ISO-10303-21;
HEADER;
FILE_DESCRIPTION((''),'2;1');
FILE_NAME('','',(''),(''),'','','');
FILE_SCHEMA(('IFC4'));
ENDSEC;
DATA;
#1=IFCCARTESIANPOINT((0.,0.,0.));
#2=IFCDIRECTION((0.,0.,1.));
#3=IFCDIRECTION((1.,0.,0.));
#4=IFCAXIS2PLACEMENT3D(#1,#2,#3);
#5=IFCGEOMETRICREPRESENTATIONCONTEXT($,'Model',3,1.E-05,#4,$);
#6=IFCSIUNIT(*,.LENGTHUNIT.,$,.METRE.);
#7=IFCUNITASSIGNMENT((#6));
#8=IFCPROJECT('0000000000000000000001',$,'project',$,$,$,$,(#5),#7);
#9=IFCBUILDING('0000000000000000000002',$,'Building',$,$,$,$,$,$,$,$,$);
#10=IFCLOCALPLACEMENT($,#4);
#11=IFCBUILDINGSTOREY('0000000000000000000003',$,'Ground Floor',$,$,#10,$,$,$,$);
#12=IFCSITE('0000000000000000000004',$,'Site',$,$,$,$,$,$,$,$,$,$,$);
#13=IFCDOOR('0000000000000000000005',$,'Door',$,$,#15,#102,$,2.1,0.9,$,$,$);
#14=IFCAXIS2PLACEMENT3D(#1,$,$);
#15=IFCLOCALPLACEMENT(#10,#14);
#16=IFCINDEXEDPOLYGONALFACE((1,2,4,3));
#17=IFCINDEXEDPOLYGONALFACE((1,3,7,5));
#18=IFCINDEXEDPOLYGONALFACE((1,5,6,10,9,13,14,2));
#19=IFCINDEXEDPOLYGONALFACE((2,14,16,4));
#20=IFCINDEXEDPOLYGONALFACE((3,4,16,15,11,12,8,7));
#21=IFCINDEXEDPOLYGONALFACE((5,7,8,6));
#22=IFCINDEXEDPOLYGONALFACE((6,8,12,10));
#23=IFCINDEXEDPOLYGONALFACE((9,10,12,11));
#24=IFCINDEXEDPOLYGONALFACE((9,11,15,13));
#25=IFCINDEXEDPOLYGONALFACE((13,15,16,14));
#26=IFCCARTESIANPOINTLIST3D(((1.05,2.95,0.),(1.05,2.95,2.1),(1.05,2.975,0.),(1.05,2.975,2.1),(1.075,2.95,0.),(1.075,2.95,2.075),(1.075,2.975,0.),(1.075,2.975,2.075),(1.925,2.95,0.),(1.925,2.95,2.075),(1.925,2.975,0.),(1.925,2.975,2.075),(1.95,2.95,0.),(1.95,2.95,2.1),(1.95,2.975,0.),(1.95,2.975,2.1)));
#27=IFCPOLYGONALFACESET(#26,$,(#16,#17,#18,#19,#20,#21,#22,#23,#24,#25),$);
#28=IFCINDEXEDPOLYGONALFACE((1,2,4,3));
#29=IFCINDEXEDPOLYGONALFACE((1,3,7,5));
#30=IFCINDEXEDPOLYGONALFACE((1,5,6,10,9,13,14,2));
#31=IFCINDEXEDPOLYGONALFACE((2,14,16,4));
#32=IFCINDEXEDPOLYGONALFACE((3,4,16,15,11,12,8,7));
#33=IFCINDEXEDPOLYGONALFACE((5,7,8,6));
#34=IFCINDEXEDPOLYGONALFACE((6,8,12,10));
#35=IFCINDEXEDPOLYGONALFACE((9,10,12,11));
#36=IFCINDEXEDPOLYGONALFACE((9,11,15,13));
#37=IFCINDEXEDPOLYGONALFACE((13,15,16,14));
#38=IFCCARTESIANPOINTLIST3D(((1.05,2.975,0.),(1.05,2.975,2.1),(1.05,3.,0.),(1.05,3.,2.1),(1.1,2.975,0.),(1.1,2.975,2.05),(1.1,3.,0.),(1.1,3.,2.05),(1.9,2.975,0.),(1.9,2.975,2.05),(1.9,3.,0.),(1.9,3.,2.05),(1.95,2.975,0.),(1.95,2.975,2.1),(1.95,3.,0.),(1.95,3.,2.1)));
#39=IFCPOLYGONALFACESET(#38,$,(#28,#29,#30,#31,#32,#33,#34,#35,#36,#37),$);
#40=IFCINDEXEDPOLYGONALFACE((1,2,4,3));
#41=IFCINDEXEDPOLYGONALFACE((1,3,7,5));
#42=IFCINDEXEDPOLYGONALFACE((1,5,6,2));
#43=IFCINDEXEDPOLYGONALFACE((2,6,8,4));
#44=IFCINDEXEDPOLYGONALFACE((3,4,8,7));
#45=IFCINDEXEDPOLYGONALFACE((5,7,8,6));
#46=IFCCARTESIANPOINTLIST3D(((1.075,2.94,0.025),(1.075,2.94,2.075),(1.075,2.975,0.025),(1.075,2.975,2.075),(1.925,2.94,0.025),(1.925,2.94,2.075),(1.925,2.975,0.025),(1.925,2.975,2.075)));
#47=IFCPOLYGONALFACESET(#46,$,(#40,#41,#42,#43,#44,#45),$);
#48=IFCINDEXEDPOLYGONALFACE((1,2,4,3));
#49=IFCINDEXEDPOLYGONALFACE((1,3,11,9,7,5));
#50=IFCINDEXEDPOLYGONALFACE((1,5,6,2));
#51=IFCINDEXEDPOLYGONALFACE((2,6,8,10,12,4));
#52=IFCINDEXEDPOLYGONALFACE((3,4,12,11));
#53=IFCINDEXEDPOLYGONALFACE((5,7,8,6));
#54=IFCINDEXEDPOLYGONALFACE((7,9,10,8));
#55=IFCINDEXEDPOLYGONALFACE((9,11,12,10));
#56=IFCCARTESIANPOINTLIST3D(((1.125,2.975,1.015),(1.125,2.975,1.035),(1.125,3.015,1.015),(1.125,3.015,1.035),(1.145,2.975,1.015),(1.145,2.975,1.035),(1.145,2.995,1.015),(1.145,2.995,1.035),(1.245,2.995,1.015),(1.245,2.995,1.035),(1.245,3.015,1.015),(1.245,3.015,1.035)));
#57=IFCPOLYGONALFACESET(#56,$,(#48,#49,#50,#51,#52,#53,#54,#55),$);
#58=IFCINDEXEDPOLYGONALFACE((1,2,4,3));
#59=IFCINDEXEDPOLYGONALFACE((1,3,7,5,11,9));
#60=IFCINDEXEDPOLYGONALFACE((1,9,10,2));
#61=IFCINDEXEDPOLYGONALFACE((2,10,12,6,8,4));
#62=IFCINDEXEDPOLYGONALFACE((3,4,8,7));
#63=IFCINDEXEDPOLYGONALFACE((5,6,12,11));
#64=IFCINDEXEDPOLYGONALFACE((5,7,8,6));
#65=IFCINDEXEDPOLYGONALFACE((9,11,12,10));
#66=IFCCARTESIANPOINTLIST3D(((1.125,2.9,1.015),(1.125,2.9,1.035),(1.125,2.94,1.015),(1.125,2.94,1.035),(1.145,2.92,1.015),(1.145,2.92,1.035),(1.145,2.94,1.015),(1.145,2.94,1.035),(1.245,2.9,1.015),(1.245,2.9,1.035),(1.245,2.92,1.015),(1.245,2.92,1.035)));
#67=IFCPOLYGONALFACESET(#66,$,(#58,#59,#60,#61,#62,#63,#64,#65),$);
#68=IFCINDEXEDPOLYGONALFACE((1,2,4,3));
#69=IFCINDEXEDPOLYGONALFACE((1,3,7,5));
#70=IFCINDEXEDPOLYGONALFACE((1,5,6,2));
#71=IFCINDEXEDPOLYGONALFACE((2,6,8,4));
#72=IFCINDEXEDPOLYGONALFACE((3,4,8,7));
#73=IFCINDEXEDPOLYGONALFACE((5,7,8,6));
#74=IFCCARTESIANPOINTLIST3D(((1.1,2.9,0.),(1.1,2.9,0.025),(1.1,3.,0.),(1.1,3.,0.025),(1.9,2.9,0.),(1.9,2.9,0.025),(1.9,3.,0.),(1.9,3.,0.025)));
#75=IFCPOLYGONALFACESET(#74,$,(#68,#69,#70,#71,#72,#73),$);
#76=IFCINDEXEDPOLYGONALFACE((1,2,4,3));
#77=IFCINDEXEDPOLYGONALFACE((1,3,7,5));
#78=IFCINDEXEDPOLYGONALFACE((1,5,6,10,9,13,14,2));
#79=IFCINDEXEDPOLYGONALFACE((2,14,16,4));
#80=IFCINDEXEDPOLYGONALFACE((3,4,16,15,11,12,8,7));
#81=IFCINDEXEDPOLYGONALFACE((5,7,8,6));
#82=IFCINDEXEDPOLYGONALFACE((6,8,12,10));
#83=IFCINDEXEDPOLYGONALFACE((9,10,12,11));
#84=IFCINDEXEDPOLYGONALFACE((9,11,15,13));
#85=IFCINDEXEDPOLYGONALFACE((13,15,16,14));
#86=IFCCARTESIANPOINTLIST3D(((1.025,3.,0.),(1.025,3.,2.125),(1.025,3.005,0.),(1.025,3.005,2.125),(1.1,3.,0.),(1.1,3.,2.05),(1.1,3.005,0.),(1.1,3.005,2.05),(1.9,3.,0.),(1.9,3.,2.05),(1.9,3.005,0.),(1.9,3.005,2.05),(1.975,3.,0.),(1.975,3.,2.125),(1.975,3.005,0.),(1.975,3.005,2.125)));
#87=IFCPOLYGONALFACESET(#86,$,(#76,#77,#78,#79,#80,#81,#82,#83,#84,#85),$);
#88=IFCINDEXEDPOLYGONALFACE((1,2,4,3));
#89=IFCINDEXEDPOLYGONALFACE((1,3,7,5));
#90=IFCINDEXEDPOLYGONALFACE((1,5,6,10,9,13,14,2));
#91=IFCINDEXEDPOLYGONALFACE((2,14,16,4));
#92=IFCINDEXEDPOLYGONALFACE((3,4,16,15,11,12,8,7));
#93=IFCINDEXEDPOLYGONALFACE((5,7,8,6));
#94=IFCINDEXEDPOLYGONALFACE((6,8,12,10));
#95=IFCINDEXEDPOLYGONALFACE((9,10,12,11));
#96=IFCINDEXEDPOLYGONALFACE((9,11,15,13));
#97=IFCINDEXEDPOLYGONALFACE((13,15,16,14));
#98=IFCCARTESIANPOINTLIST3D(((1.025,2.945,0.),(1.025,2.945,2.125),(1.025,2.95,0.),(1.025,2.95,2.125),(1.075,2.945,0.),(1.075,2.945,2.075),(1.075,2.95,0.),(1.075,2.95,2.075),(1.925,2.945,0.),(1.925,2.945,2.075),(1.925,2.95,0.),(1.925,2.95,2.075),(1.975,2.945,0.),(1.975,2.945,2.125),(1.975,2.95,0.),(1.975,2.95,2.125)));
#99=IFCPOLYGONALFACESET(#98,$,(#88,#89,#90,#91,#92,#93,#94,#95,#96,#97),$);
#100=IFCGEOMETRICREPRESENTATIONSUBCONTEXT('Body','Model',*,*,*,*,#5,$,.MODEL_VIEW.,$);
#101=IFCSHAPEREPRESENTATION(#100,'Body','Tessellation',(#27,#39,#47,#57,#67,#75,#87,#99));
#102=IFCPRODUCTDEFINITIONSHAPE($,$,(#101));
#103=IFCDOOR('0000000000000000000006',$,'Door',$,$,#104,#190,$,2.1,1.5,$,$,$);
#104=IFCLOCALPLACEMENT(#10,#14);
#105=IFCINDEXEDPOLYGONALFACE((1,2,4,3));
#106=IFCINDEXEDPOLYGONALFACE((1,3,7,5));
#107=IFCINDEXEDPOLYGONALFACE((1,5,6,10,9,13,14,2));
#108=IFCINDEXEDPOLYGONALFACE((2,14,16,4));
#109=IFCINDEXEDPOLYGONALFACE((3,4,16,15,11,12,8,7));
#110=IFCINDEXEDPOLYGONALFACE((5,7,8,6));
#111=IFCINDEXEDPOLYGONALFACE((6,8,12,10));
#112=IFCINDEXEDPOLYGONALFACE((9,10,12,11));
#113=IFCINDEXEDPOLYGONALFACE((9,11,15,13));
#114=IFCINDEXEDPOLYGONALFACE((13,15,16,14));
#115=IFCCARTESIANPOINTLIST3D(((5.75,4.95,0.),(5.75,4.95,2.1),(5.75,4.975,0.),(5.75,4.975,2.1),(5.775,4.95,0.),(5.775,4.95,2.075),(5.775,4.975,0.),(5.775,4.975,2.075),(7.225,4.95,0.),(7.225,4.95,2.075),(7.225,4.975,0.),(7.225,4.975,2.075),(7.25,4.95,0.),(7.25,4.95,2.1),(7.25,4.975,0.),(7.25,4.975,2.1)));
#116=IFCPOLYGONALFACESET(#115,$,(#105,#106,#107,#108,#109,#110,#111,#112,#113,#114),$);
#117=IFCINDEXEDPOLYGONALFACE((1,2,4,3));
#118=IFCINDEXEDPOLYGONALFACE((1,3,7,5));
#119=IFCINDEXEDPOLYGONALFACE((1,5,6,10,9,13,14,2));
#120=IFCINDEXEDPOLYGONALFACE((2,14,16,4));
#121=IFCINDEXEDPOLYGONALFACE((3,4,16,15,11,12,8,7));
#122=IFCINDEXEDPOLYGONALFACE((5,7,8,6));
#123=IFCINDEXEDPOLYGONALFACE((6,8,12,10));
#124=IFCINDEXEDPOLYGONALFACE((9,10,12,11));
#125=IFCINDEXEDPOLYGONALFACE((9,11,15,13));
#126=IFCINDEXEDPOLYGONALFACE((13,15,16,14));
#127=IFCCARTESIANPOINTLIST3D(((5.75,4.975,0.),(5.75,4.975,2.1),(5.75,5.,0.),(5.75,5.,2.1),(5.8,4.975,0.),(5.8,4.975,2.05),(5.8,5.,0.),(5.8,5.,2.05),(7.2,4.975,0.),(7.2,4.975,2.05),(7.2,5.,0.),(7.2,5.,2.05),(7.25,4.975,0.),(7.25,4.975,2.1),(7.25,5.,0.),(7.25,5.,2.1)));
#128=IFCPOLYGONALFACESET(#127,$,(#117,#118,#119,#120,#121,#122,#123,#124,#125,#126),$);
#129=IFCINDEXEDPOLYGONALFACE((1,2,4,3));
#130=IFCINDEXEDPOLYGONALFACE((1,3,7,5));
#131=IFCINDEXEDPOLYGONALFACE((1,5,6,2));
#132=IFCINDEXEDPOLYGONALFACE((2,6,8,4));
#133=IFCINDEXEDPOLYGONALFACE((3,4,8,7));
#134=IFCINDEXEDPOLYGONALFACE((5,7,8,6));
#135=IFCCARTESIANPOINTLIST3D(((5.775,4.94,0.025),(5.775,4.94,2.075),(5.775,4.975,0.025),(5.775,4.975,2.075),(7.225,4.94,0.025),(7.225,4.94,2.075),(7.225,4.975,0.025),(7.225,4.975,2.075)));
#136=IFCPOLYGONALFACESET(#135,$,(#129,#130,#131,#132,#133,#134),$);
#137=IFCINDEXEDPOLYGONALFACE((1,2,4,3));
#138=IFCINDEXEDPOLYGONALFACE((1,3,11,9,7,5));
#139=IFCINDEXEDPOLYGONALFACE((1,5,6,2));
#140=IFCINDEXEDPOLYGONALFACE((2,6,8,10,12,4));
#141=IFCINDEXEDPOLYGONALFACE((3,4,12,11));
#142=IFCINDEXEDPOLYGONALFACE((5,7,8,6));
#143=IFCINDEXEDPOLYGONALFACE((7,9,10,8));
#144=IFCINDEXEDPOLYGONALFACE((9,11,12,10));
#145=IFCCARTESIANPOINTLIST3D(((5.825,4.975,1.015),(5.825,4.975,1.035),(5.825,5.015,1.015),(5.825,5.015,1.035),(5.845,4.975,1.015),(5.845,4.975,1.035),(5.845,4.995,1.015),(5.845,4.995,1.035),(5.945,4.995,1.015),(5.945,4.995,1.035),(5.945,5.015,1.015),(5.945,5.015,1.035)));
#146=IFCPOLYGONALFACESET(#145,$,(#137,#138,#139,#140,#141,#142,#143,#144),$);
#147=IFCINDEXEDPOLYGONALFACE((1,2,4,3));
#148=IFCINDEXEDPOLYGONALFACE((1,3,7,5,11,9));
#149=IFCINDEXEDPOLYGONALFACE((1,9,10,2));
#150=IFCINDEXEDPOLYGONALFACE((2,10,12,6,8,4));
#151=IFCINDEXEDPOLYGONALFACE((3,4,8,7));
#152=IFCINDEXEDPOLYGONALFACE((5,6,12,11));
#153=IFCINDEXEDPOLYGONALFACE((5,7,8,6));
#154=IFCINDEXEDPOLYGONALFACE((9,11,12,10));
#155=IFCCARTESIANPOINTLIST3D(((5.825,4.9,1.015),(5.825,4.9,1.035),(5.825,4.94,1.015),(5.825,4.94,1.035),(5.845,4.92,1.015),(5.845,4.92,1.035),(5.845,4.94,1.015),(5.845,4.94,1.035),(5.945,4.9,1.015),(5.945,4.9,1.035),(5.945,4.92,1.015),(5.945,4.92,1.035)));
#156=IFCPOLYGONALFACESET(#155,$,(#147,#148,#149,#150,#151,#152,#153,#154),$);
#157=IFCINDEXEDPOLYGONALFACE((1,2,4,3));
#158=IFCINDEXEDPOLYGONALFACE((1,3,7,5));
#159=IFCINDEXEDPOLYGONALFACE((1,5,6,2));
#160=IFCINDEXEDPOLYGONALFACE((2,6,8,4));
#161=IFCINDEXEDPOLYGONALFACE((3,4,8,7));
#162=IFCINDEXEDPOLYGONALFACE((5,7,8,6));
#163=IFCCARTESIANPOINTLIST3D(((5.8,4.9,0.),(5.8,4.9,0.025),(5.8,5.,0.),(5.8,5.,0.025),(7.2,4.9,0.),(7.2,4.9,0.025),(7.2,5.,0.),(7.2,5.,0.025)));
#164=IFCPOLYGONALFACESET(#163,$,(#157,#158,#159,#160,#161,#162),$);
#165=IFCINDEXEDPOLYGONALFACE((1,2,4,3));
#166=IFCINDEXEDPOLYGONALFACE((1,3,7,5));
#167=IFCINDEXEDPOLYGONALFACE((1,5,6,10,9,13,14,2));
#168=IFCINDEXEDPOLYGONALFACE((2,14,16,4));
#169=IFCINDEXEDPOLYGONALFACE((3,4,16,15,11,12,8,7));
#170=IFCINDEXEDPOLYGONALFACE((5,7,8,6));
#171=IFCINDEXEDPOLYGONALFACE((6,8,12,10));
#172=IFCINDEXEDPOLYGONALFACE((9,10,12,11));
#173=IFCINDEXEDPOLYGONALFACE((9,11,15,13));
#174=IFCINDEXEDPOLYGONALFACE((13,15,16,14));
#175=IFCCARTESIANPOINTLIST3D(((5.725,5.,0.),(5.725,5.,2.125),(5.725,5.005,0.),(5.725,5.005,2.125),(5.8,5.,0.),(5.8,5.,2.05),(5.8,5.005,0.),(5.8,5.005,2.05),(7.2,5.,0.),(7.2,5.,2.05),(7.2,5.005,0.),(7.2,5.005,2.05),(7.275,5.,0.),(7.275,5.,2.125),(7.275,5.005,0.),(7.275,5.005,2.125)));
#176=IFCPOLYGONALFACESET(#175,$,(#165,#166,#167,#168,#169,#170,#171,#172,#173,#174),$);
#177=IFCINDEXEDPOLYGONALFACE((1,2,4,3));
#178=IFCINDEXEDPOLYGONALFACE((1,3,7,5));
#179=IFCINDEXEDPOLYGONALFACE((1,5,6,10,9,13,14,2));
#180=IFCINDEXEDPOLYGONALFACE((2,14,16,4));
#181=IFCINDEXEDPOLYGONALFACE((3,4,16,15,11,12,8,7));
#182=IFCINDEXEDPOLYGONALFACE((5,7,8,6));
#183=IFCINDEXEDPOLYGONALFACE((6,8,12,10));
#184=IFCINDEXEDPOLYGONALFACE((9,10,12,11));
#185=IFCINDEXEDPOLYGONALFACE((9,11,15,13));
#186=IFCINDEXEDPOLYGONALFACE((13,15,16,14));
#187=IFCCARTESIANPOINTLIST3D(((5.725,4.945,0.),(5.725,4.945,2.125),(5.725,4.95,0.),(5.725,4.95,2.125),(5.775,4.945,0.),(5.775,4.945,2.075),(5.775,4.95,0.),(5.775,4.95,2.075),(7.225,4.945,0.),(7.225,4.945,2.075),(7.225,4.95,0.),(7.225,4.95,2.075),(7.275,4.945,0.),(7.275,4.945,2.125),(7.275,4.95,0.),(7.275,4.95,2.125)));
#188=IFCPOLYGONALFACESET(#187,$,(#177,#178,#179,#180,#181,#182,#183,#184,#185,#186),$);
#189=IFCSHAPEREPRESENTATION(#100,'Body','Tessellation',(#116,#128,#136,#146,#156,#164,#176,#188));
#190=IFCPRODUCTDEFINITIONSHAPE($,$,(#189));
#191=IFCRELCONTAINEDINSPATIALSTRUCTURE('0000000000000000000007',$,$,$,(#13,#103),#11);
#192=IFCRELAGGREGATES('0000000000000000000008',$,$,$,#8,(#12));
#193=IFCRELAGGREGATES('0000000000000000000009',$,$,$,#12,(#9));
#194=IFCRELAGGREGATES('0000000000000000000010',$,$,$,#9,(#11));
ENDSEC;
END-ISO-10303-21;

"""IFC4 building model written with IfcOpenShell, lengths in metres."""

from ifc_helpers import new_model, si_unit, frame, origin_with_axes, place, context, subcontext, project, spatial, line, indexed_curve, outline, extrude, element, save


model = new_model("IFC4")

# Units and contexts
model_context = context("Model", 3, precision=1e-05, world=origin_with_axes())
body_context = subcontext(model_context, "Body", "Model", "MODEL_VIEW")
ifc_project = project(units=[si_unit("LENGTHUNIT", "METRE")], contexts=[model_context])

# Site, building, storey
site = spatial("IfcSite", under=ifc_project, Name="Site")
building = spatial("IfcBuilding", under=site, Name="Building")
storey_placement = place(None, origin_with_axes())
storey = spatial("IfcBuildingStorey", under=building, at=storey_placement, Name="Ground Floor")

# Doors
door_1_placement = place(storey_placement, frame((1.95, 3.0, 0.0), z_axis=(0.0, 0.0, 1.0), x_axis=(-1.0, 0.0, 0.0)))
element("IfcDoor", 1, at=door_1_placement, inside=storey, Name="Door", OverallHeight=2.1, OverallWidth=0.9, context=body_context, shape_type="SweptSolid", body=[
    extrude(outline(indexed_curve([(0.0, 0.0), (0.0, 2.1), (0.9, 2.1), (0.9, 0.0), (0.875, 0.0), (0.875, 2.075), (0.025, 2.075), (0.025, 0.0)], segments=[line(1, 2, 3, 4, 5, 6, 7, 8, 1)])), frame((0.0, 0.025, 0.0), z_axis=(0.0, -1.0, 0.0), x_axis=(1.0, 0.0, 0.0)), (0.0, 0.0, -1.0), 0.025),
    extrude(outline(indexed_curve([(0.0, 0.0), (0.0, 2.1), (0.9, 2.1), (0.9, 0.0), (0.85, 0.0), (0.85, 2.05), (0.05, 2.05), (0.05, 0.0)], segments=[line(1, 2, 3, 4, 5, 6, 7, 8, 1)])), frame((0.0, 0.0, 0.0), z_axis=(0.0, -1.0, 0.0), x_axis=(1.0, 0.0, 0.0)), (0.0, 0.0, -1.0), 0.025),
    extrude(outline(indexed_curve([(0.0, 0.0), (0.85, 0.0), (0.85, 0.035), (0.0, 0.035)], segments=[line(1, 2, 3, 4, 1)])), frame((0.025, 0.025, 0.025), z_axis=(0.0, 0.0, 1.0), x_axis=(1.0, 0.0, 0.0)), (0.0, 0.0, 1.0), 2.05),
    extrude(outline(indexed_curve([(0.0, 0.0), (0.0, -0.04), (-0.12, -0.04), (-0.12, -0.02), (-0.02, -0.02), (-0.02, 0.0)], segments=[line(1, 2, 3, 4, 5, 6, 1)])), frame((0.825, 0.025, 1.015), z_axis=(0.0, 0.0, 1.0), x_axis=(1.0, 0.0, 0.0)), (0.0, 0.0, 1.0), 0.02),
    extrude(outline(indexed_curve([(0.0, 0.0), (0.0, 0.04), (-0.12, 0.04), (-0.12, 0.02), (-0.02, 0.02), (-0.02, 0.0)], segments=[line(1, 2, 3, 4, 5, 6, 1)])), frame((0.825, 0.06, 1.015), z_axis=(0.0, 0.0, 1.0), x_axis=(1.0, 0.0, 0.0)), (0.0, 0.0, 1.0), 0.02),
    extrude(outline(indexed_curve([(0.0, 0.0), (0.8, 0.0), (0.8, 0.1), (0.0, 0.1)], segments=[line(1, 2, 3, 4, 1)])), frame((0.05, 0.0, 0.0), z_axis=(0.0, 0.0, 1.0), x_axis=(1.0, 0.0, 0.0)), (0.0, 0.0, 1.0), 0.025),
    extrude(outline(indexed_curve([(0.0, 0.0), (0.0, 2.125), (0.95, 2.125), (0.95, 0.0), (0.875, 0.0), (0.875, 2.05), (0.075, 2.05), (0.075, 0.0)], segments=[line(1, 2, 3, 4, 5, 6, 7, 8, 1)])), frame((-0.025, -0.005, 0.0), z_axis=(0.0, -1.0, 0.0), x_axis=(1.0, 0.0, 0.0)), (0.0, 0.0, -1.0), 0.005),
    extrude(outline(indexed_curve([(0.0, 0.0), (0.0, 2.125), (0.95, 2.125), (0.95, 0.0), (0.9, 0.0), (0.9, 2.075), (0.05, 2.075), (0.05, 0.0)], segments=[line(1, 2, 3, 4, 5, 6, 7, 8, 1)])), frame((-0.025, 0.05, 0.0), z_axis=(0.0, -1.0, 0.0), x_axis=(1.0, 0.0, 0.0)), (0.0, 0.0, -1.0), 0.005),
])
door_2_placement = place(storey_placement, frame((7.25, 5.0, 0.0), z_axis=(0.0, 0.0, 1.0), x_axis=(-1.0, 0.0, 0.0)))
element("IfcDoor", 2, at=door_2_placement, inside=storey, Name="Door", OverallHeight=2.1, OverallWidth=1.5, context=body_context, shape_type="SweptSolid", body=[
    extrude(outline(indexed_curve([(0.0, 0.0), (0.0, 2.1), (1.5, 2.1), (1.5, 0.0), (1.475, 0.0), (1.475, 2.075), (0.025, 2.075), (0.025, 0.0)], segments=[line(1, 2, 3, 4, 5, 6, 7, 8, 1)])), frame((0.0, 0.025, 0.0), z_axis=(0.0, -1.0, 0.0), x_axis=(1.0, 0.0, 0.0)), (0.0, 0.0, -1.0), 0.025),
    extrude(outline(indexed_curve([(0.0, 0.0), (0.0, 2.1), (1.5, 2.1), (1.5, 0.0), (1.45, 0.0), (1.45, 2.05), (0.05, 2.05), (0.05, 0.0)], segments=[line(1, 2, 3, 4, 5, 6, 7, 8, 1)])), frame((0.0, 0.0, 0.0), z_axis=(0.0, -1.0, 0.0), x_axis=(1.0, 0.0, 0.0)), (0.0, 0.0, -1.0), 0.025),
    extrude(outline(indexed_curve([(0.0, 0.0), (1.45, 0.0), (1.45, 0.035), (0.0, 0.035)], segments=[line(1, 2, 3, 4, 1)])), frame((0.025, 0.025, 0.025), z_axis=(0.0, 0.0, 1.0), x_axis=(1.0, 0.0, 0.0)), (0.0, 0.0, 1.0), 2.05),
    extrude(outline(indexed_curve([(0.0, 0.0), (0.0, -0.04), (-0.12, -0.04), (-0.12, -0.02), (-0.02, -0.02), (-0.02, 0.0)], segments=[line(1, 2, 3, 4, 5, 6, 1)])), frame((1.425, 0.025, 1.015), z_axis=(0.0, 0.0, 1.0), x_axis=(1.0, 0.0, 0.0)), (0.0, 0.0, 1.0), 0.02),
    extrude(outline(indexed_curve([(0.0, 0.0), (0.0, 0.04), (-0.12, 0.04), (-0.12, 0.02), (-0.02, 0.02), (-0.02, 0.0)], segments=[line(1, 2, 3, 4, 5, 6, 1)])), frame((1.425, 0.06, 1.015), z_axis=(0.0, 0.0, 1.0), x_axis=(1.0, 0.0, 0.0)), (0.0, 0.0, 1.0), 0.02),
    extrude(outline(indexed_curve([(0.0, 0.0), (1.4, 0.0), (1.4, 0.1), (0.0, 0.1)], segments=[line(1, 2, 3, 4, 1)])), frame((0.05, 0.0, 0.0), z_axis=(0.0, 0.0, 1.0), x_axis=(1.0, 0.0, 0.0)), (0.0, 0.0, 1.0), 0.025),
    extrude(outline(indexed_curve([(0.0, 0.0), (0.0, 2.125), (1.55, 2.125), (1.55, 0.0), (1.475, 0.0), (1.475, 2.05), (0.075, 2.05), (0.075, 0.0)], segments=[line(1, 2, 3, 4, 5, 6, 7, 8, 1)])), frame((-0.025, -0.005, 0.0), z_axis=(0.0, -1.0, 0.0), x_axis=(1.0, 0.0, 0.0)), (0.0, 0.0, -1.0), 0.005),
    extrude(outline(indexed_curve([(0.0, 0.0), (0.0, 2.125), (1.55, 2.125), (1.55, 0.0), (1.5, 0.0), (1.5, 2.075), (0.05, 2.075), (0.05, 0.0)], segments=[line(1, 2, 3, 4, 5, 6, 7, 8, 1)])), frame((-0.025, 0.05, 0.0), z_axis=(0.0, -1.0, 0.0), x_axis=(1.0, 0.0, 0.0)), (0.0, 0.0, -1.0), 0.005),
])

save(model, "model.ifc")
